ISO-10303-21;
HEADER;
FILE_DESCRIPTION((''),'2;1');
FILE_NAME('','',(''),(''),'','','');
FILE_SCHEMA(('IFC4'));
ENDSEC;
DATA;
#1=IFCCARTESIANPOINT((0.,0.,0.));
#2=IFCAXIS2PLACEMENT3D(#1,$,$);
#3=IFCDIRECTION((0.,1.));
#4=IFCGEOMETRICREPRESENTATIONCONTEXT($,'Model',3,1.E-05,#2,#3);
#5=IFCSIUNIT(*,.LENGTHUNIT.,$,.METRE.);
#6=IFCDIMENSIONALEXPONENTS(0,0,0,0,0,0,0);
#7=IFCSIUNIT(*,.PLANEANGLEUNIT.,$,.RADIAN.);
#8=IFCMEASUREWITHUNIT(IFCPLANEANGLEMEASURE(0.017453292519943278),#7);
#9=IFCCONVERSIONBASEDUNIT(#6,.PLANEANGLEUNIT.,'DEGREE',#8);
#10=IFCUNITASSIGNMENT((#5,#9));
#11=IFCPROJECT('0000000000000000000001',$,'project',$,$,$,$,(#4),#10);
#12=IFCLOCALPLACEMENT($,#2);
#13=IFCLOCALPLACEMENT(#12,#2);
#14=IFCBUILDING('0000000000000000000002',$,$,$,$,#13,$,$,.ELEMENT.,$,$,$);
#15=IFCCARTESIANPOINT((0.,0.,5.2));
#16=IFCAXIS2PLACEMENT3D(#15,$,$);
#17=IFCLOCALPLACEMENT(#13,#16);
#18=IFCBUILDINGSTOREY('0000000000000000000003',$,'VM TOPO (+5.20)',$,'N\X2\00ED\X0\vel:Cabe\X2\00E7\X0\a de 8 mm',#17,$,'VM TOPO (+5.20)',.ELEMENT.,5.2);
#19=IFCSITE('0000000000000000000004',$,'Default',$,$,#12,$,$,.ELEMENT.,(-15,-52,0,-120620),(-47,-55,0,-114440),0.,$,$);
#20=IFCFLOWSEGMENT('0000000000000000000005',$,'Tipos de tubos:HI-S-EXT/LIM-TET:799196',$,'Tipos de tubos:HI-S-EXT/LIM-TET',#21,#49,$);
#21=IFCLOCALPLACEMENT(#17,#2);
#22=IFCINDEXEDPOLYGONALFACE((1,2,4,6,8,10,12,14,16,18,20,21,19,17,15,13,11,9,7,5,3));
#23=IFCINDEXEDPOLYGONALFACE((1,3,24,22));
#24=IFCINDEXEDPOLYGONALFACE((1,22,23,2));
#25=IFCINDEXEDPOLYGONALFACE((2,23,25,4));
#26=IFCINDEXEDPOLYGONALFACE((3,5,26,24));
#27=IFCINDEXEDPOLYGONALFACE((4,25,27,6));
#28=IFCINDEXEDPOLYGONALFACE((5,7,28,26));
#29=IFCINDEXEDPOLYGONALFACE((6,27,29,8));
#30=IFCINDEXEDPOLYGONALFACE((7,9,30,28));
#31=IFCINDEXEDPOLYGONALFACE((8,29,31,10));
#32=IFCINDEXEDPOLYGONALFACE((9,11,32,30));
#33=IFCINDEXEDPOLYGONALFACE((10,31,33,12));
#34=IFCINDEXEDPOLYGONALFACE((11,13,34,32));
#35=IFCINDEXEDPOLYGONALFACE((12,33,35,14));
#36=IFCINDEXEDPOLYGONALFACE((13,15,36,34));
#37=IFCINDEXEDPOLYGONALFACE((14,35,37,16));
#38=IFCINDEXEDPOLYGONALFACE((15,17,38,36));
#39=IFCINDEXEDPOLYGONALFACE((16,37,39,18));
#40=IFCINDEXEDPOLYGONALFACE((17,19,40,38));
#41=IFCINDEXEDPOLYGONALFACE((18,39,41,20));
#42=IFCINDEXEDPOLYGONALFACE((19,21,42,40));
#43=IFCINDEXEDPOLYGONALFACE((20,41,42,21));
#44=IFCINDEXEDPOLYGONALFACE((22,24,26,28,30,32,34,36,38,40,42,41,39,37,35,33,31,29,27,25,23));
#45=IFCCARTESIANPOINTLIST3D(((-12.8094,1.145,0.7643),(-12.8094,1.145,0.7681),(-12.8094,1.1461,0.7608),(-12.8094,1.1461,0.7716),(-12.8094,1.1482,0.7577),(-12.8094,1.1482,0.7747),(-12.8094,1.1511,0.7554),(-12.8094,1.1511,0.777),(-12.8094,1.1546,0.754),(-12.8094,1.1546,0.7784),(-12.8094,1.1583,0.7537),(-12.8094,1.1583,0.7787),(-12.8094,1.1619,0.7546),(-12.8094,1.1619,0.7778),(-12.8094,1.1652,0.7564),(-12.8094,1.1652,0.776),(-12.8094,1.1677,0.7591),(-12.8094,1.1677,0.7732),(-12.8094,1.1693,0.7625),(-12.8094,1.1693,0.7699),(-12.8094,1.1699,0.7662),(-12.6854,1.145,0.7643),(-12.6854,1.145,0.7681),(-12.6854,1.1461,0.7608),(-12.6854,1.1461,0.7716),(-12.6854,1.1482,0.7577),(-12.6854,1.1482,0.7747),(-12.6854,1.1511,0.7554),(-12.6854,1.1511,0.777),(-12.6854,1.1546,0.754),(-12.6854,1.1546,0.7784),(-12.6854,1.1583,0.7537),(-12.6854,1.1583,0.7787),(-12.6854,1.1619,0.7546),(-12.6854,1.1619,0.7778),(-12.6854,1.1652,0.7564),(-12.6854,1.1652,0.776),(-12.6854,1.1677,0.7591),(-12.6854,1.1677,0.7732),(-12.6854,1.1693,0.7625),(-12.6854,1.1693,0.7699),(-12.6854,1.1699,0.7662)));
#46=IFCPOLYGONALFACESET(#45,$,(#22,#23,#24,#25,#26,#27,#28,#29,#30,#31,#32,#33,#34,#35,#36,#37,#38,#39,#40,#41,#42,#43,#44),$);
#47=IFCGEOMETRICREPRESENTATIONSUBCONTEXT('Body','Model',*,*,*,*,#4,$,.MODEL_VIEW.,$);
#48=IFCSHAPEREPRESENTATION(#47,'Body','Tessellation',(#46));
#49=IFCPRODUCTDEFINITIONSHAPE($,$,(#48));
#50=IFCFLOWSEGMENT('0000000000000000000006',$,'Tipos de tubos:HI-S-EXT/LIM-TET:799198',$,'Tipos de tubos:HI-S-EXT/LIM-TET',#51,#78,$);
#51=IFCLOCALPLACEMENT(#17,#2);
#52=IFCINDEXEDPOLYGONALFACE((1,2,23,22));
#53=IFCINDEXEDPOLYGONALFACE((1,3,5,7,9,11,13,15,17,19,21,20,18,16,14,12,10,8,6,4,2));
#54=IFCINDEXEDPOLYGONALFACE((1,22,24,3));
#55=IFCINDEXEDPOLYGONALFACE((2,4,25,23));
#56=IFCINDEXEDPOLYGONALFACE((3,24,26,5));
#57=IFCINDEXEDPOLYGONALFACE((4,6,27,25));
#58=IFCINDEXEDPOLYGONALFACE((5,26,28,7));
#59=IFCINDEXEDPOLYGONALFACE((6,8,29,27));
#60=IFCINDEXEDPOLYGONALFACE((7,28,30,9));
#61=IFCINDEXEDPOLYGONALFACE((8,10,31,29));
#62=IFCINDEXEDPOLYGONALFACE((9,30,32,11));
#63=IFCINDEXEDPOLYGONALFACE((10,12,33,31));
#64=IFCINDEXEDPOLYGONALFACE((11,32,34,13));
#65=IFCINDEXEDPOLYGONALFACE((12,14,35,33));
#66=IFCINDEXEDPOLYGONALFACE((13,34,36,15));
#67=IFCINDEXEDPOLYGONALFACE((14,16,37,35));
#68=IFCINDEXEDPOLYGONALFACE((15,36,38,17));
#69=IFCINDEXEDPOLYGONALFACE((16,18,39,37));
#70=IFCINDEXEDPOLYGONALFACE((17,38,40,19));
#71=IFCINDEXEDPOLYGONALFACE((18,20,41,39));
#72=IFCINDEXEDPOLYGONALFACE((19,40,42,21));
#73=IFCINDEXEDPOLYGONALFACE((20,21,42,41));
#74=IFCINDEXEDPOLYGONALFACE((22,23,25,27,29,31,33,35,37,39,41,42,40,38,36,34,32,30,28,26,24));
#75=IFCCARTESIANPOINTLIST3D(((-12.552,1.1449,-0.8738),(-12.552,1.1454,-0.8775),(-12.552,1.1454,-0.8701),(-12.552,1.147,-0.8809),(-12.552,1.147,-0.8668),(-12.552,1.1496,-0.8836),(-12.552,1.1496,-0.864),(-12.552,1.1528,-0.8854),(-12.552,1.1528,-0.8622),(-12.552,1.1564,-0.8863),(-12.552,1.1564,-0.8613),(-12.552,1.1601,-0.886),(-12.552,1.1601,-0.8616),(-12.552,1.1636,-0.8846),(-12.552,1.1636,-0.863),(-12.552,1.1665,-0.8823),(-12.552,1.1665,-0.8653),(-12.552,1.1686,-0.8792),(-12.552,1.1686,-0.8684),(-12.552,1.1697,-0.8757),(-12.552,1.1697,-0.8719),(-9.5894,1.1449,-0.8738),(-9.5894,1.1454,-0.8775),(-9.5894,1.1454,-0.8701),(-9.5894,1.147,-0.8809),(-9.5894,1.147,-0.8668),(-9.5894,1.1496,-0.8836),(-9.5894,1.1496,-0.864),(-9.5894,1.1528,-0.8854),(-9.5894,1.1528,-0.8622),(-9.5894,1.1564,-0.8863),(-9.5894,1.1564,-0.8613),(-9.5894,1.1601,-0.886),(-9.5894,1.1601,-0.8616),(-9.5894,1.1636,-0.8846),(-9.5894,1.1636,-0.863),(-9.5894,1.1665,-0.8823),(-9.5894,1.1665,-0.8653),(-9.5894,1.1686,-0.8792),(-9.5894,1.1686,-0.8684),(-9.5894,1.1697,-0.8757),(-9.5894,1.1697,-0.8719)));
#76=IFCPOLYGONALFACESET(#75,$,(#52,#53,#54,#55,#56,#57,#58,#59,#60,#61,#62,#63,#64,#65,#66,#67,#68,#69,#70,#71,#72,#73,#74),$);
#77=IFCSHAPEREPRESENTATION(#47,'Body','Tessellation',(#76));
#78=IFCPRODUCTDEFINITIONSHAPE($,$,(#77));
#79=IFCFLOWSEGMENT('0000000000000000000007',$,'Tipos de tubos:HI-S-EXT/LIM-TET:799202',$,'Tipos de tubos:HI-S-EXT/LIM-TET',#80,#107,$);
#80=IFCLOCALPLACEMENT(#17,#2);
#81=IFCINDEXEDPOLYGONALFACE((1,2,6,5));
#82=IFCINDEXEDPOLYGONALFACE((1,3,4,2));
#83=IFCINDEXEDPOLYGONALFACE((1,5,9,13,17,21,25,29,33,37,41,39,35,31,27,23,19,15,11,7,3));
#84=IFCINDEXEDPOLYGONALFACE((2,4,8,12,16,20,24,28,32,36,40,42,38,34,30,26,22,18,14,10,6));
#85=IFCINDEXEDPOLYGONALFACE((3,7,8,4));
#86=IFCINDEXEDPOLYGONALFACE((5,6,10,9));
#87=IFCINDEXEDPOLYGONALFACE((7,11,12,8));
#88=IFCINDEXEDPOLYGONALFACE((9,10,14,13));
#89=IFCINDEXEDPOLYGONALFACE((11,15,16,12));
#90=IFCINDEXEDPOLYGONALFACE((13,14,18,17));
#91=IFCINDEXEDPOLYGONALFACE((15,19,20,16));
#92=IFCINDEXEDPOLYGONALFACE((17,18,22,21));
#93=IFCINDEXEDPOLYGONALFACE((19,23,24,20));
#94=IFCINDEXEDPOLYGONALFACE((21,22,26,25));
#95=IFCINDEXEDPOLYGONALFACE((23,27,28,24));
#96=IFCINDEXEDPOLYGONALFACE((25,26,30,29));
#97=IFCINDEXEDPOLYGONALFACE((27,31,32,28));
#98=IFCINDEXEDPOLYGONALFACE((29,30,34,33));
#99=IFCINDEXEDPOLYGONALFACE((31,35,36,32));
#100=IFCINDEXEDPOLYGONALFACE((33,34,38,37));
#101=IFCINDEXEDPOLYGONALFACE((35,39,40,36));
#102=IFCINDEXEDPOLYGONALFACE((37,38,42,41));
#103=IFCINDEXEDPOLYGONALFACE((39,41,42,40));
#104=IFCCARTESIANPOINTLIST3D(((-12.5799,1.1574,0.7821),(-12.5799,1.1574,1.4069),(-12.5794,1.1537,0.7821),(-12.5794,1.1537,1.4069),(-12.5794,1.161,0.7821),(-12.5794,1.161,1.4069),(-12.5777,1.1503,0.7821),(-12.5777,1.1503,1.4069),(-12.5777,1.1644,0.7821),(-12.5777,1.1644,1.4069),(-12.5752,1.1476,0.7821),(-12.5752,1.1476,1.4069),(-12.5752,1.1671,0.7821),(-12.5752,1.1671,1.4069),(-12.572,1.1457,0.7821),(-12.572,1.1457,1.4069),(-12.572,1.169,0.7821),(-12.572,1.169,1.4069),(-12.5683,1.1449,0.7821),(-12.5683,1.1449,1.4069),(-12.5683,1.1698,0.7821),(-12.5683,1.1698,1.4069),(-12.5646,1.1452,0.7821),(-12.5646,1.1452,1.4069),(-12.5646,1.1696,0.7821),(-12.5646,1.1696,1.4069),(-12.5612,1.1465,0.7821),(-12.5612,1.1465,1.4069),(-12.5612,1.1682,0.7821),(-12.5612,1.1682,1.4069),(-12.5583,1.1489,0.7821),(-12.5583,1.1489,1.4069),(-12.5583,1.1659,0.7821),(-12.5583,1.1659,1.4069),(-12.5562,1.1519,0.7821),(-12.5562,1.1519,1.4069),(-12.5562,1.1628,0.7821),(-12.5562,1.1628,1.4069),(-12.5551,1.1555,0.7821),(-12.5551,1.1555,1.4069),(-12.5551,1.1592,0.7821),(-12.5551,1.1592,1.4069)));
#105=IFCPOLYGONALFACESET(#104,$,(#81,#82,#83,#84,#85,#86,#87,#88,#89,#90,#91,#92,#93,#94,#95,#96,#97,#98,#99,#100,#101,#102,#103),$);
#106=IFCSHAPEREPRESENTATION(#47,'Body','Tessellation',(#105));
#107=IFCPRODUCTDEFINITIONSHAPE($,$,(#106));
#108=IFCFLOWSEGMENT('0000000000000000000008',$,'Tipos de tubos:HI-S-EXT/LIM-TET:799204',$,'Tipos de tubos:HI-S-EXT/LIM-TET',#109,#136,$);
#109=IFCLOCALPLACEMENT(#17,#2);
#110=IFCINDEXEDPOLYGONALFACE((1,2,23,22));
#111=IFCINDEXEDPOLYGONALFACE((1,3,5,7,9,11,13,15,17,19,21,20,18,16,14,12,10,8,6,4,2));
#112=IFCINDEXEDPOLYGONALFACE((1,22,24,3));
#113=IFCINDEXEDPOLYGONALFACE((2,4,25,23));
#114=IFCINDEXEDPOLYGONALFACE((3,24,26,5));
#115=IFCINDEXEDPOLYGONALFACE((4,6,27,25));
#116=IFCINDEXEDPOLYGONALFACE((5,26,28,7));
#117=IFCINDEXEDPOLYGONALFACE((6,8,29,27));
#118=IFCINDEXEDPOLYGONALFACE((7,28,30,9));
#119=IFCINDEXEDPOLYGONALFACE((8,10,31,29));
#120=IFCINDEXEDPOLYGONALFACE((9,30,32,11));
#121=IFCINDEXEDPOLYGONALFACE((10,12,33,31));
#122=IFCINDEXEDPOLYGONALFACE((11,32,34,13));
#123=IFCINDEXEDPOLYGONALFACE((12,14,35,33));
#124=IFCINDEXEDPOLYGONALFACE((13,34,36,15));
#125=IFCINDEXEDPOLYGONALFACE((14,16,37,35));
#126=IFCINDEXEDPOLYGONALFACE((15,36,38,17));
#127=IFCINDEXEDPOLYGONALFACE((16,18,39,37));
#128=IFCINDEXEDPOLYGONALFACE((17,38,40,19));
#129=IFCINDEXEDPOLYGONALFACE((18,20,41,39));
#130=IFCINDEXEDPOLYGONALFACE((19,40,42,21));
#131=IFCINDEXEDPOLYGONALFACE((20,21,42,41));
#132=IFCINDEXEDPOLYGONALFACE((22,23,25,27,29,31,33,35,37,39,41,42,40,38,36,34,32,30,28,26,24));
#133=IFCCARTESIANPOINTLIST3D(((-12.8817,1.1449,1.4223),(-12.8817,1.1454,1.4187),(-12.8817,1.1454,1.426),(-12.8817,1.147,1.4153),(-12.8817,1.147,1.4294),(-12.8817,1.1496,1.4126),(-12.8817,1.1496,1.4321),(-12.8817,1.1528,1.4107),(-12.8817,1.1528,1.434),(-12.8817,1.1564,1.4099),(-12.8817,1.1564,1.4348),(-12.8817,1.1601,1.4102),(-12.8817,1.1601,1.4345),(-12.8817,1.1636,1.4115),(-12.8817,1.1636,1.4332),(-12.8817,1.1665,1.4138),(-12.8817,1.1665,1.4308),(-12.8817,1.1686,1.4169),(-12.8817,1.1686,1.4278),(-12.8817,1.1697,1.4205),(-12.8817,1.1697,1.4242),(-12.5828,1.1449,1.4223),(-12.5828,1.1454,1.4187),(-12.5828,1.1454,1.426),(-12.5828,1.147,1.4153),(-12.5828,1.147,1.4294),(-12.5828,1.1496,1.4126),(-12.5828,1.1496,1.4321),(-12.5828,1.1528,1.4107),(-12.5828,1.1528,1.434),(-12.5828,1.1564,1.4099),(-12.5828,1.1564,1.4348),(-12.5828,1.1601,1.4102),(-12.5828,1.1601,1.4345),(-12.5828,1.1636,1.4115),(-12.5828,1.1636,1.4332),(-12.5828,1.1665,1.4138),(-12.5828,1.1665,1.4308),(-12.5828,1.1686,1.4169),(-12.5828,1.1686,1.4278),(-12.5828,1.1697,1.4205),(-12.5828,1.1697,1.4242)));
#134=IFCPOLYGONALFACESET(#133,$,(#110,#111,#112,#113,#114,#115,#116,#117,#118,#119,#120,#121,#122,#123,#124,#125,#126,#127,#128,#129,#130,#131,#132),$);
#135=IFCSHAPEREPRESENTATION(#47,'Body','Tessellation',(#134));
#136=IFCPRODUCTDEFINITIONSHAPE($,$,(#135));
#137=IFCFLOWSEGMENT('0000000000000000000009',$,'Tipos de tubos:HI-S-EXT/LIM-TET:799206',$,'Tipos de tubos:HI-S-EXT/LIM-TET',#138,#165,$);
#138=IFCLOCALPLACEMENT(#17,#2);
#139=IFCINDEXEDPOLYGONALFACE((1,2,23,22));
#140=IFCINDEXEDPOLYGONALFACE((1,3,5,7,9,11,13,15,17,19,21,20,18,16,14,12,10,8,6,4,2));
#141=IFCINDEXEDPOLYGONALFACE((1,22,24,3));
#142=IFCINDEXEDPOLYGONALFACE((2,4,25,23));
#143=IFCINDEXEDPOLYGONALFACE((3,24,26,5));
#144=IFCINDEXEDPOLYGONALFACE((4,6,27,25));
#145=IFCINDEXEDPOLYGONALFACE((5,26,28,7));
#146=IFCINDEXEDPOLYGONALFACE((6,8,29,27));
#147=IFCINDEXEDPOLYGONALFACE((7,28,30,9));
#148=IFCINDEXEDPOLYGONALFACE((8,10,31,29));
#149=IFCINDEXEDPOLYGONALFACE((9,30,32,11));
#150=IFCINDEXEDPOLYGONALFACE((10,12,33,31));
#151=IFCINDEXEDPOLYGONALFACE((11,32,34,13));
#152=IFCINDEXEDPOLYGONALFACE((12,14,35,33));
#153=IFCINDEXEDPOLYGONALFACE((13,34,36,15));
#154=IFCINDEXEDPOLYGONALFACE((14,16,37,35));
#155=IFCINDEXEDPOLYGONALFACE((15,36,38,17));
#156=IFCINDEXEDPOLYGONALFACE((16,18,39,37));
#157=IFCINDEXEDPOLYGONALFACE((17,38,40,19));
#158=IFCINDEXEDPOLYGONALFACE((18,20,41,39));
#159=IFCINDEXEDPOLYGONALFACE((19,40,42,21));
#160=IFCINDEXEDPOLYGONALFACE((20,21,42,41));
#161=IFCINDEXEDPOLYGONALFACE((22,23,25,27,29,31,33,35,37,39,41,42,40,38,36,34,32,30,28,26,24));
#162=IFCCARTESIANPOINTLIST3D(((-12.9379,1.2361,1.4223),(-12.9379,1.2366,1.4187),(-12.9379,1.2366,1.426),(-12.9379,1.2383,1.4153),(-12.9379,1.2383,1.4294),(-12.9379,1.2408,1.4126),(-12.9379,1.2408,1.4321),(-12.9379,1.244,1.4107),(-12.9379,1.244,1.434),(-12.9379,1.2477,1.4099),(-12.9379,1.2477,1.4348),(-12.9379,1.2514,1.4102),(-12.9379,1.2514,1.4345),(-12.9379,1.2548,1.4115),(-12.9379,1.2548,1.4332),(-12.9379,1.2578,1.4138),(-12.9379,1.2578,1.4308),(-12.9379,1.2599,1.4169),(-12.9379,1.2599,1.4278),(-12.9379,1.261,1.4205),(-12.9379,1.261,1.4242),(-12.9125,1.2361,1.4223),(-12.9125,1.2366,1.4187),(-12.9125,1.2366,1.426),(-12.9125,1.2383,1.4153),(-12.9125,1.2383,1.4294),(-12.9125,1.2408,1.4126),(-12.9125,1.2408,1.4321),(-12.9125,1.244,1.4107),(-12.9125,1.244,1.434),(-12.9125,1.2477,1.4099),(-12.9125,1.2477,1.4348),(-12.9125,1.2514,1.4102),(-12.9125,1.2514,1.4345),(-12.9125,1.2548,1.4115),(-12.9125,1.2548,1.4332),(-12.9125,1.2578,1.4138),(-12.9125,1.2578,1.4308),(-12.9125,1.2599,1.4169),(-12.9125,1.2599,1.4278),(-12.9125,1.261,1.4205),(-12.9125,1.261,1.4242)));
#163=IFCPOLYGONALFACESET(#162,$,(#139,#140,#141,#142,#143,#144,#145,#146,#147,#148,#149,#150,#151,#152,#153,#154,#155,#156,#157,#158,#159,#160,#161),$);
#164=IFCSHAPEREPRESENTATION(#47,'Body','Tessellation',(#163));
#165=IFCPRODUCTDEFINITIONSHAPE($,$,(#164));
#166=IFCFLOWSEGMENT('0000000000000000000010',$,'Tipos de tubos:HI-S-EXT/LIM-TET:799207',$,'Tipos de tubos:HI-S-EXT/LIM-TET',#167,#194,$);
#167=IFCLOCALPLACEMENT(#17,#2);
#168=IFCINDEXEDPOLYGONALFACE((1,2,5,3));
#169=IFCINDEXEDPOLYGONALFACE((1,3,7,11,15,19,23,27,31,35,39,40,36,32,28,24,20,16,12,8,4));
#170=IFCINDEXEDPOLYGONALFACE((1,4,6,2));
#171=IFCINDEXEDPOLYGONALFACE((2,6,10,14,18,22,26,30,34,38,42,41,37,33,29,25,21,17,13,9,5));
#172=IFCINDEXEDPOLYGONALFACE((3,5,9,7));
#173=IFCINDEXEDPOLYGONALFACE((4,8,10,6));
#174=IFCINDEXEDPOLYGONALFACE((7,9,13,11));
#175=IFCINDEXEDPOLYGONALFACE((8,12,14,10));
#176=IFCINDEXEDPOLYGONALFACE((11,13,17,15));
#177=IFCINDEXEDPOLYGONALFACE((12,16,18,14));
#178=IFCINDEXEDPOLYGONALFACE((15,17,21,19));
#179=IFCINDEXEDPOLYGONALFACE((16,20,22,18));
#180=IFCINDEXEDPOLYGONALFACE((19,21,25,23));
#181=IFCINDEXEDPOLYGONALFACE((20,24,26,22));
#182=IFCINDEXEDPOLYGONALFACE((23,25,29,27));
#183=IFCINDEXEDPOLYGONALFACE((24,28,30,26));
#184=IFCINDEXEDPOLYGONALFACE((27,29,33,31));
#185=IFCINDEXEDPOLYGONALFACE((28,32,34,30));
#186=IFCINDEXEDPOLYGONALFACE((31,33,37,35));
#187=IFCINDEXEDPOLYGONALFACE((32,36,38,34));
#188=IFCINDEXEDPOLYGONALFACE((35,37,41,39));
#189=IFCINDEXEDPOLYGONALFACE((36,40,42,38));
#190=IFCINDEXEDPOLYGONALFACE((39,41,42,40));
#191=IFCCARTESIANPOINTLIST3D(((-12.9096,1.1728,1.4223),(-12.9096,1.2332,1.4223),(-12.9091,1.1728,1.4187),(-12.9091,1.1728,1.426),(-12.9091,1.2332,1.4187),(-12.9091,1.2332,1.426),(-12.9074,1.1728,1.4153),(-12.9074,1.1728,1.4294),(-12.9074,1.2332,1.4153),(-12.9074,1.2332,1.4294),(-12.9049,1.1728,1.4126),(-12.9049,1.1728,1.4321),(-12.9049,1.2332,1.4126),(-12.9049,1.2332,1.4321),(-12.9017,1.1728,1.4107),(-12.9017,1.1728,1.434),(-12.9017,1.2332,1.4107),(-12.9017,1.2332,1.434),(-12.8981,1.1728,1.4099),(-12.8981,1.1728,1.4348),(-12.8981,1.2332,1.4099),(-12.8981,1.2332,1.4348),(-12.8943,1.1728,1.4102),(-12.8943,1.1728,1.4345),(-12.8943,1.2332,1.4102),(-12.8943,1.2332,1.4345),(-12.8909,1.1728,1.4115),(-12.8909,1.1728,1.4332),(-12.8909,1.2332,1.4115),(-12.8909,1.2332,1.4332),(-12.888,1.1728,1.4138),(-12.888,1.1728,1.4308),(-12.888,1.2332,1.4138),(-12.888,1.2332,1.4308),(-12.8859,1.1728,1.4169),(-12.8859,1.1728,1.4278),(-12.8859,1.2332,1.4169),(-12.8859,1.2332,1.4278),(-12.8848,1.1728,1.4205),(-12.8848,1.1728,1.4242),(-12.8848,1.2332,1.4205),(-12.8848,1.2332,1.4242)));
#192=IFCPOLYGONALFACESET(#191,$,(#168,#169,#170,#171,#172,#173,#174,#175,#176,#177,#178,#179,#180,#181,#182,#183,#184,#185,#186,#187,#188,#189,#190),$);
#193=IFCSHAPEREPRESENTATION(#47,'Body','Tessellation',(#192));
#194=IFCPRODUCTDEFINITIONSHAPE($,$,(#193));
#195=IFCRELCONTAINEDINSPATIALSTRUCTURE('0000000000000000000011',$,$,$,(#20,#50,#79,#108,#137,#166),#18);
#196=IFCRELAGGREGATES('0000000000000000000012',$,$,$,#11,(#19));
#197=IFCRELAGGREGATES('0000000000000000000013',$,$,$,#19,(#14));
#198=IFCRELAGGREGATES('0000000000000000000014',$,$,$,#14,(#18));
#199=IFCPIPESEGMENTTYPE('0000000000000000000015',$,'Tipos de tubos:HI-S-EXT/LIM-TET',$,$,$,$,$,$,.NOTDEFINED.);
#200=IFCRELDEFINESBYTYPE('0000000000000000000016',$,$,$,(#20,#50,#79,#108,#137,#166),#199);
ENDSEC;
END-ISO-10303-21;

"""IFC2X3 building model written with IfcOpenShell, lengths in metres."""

from ifc_helpers import new_model, entity, si_unit, converted_unit, direction, frame, frame_2d, origin, origin_2d_with_axis, place, context, subcontext, project, spatial, circle, extrude, type_object, element, save


model = new_model("IFC2X3")

# Units and contexts
model_context = context("Model", 3, precision=1e-05, world=origin(), true_north=direction((0.0, 1.0)))
body_context = subcontext(model_context, "Body", "Model", "MODEL_VIEW")
ifc_project = project(units=[si_unit("LENGTHUNIT", "METRE"), converted_unit("PLANEANGLEUNIT", "DEGREE", entity("IfcPlaneAngleMeasure", 0.017453292519943278), si_unit("PLANEANGLEUNIT", "RADIAN"), dimensions=[0, 0, 0, 0, 0, 0, 0])], contexts=[model_context])

# Site, building, storey
site_placement = place(None, origin())
site = spatial("IfcSite", under=ifc_project, at=site_placement, Name="Default", CompositionType="ELEMENT", RefLatitude=(-15, -52, 0, -120620), RefLongitude=(-47, -55, 0, -114440), RefElevation=0.0)
building_placement = place(site_placement, origin())
building = spatial("IfcBuilding", under=site, at=building_placement, CompositionType="ELEMENT")
storey_placement = place(building_placement, frame((0.0, 0.0, 5.2)))
storey = spatial("IfcBuildingStorey", under=building, at=storey_placement, Name="VM TOPO (+5.20)", ObjectType="Nível:Cabeça de 8 mm", LongName="VM TOPO (+5.20)", CompositionType="ELEMENT", Elevation=5.2)

# Flow segments
pipe_segment_type_1 = type_object("IfcPipeSegmentType", Name="Tipos de tubos:HI-S-EXT/LIM-TET", PredefinedType="NOTDEFINED")
flow_segment_1_placement = place(storey_placement, origin())
element("IfcFlowSegment", 1, at=flow_segment_1_placement, inside=storey, type_object=pipe_segment_type_1, Name="Tipos de tubos:HI-S-EXT/LIM-TET:799196", ObjectType="Tipos de tubos:HI-S-EXT/LIM-TET", context=body_context, shape_type="SweptSolid", body=[
    extrude(circle(Radius=0.0125, at=origin_2d_with_axis()), frame((-12.8094, 1.1574, 0.7662), z_axis=(1.0, 0.0, 0.0), x_axis=(0.0, 1.0, 0.0)), (0.0, 0.0, 1.0), 0.124),
])
flow_segment_2_placement = place(storey_placement, origin())
element("IfcFlowSegment", 2, at=flow_segment_2_placement, inside=storey, type_object=pipe_segment_type_1, Name="Tipos de tubos:HI-S-EXT/LIM-TET:799198", ObjectType="Tipos de tubos:HI-S-EXT/LIM-TET", context=body_context, shape_type="SweptSolid", body=[
    extrude(circle(Radius=0.0125, at=frame_2d((0.0, 0.0), x_axis=(1.0, 0.0))), frame((-12.552, 1.1574, -0.8738), z_axis=(1.0, 0.0, 0.0), x_axis=(0.0, -1.0, 0.0)), (0.0, 0.0, 1.0), 2.9626),
])
flow_segment_3_placement = place(storey_placement, origin())
element("IfcFlowSegment", 3, at=flow_segment_3_placement, inside=storey, type_object=pipe_segment_type_1, Name="Tipos de tubos:HI-S-EXT/LIM-TET:799202", ObjectType="Tipos de tubos:HI-S-EXT/LIM-TET", context=body_context, shape_type="SweptSolid", body=[
    extrude(circle(Radius=0.0125, at=origin_2d_with_axis()), frame((-12.5674, 1.1574, 0.7821), z_axis=(0.0, 0.0, 1.0), x_axis=(-1.0, 0.0, 0.0)), (0.0, 0.0, 1.0), 0.6249),
])
flow_segment_4_placement = place(storey_placement, origin())
element("IfcFlowSegment", 4, at=flow_segment_4_placement, inside=storey, type_object=pipe_segment_type_1, Name="Tipos de tubos:HI-S-EXT/LIM-TET:799204", ObjectType="Tipos de tubos:HI-S-EXT/LIM-TET", context=body_context, shape_type="SweptSolid", body=[
    extrude(circle(Radius=0.0125, at=origin_2d_with_axis()), frame((-12.8817, 1.1574, 1.4223), z_axis=(1.0, 0.0, 0.0), x_axis=(0.0, -1.0, 0.0)), (0.0, 0.0, 1.0), 0.2989),
])
flow_segment_5_placement = place(storey_placement, origin())
element("IfcFlowSegment", 5, at=flow_segment_5_placement, inside=storey, type_object=pipe_segment_type_1, Name="Tipos de tubos:HI-S-EXT/LIM-TET:799206", ObjectType="Tipos de tubos:HI-S-EXT/LIM-TET", context=body_context, shape_type="SweptSolid", body=[
    extrude(circle(Radius=0.0125, at=origin_2d_with_axis()), frame((-12.9379, 1.2486, 1.4223), z_axis=(1.0, 0.0, 0.0), x_axis=(0.0, -1.0, 0.0)), (0.0, 0.0, 1.0), 0.0254),
])
flow_segment_6_placement = place(storey_placement, origin())
element("IfcFlowSegment", 6, at=flow_segment_6_placement, inside=storey, type_object=pipe_segment_type_1, Name="Tipos de tubos:HI-S-EXT/LIM-TET:799207", ObjectType="Tipos de tubos:HI-S-EXT/LIM-TET", context=body_context, shape_type="SweptSolid", body=[
    extrude(circle(Radius=0.0125, at=frame_2d((0.0, 0.0), x_axis=(1.0, 0.0))), frame((-12.8971, 1.1728, 1.4223), z_axis=(0.0, 1.0, 0.0), x_axis=(-1.0, 0.0, 0.0)), (0.0, 0.0, 1.0), 0.0604),
])

save(model, "model.ifc")
